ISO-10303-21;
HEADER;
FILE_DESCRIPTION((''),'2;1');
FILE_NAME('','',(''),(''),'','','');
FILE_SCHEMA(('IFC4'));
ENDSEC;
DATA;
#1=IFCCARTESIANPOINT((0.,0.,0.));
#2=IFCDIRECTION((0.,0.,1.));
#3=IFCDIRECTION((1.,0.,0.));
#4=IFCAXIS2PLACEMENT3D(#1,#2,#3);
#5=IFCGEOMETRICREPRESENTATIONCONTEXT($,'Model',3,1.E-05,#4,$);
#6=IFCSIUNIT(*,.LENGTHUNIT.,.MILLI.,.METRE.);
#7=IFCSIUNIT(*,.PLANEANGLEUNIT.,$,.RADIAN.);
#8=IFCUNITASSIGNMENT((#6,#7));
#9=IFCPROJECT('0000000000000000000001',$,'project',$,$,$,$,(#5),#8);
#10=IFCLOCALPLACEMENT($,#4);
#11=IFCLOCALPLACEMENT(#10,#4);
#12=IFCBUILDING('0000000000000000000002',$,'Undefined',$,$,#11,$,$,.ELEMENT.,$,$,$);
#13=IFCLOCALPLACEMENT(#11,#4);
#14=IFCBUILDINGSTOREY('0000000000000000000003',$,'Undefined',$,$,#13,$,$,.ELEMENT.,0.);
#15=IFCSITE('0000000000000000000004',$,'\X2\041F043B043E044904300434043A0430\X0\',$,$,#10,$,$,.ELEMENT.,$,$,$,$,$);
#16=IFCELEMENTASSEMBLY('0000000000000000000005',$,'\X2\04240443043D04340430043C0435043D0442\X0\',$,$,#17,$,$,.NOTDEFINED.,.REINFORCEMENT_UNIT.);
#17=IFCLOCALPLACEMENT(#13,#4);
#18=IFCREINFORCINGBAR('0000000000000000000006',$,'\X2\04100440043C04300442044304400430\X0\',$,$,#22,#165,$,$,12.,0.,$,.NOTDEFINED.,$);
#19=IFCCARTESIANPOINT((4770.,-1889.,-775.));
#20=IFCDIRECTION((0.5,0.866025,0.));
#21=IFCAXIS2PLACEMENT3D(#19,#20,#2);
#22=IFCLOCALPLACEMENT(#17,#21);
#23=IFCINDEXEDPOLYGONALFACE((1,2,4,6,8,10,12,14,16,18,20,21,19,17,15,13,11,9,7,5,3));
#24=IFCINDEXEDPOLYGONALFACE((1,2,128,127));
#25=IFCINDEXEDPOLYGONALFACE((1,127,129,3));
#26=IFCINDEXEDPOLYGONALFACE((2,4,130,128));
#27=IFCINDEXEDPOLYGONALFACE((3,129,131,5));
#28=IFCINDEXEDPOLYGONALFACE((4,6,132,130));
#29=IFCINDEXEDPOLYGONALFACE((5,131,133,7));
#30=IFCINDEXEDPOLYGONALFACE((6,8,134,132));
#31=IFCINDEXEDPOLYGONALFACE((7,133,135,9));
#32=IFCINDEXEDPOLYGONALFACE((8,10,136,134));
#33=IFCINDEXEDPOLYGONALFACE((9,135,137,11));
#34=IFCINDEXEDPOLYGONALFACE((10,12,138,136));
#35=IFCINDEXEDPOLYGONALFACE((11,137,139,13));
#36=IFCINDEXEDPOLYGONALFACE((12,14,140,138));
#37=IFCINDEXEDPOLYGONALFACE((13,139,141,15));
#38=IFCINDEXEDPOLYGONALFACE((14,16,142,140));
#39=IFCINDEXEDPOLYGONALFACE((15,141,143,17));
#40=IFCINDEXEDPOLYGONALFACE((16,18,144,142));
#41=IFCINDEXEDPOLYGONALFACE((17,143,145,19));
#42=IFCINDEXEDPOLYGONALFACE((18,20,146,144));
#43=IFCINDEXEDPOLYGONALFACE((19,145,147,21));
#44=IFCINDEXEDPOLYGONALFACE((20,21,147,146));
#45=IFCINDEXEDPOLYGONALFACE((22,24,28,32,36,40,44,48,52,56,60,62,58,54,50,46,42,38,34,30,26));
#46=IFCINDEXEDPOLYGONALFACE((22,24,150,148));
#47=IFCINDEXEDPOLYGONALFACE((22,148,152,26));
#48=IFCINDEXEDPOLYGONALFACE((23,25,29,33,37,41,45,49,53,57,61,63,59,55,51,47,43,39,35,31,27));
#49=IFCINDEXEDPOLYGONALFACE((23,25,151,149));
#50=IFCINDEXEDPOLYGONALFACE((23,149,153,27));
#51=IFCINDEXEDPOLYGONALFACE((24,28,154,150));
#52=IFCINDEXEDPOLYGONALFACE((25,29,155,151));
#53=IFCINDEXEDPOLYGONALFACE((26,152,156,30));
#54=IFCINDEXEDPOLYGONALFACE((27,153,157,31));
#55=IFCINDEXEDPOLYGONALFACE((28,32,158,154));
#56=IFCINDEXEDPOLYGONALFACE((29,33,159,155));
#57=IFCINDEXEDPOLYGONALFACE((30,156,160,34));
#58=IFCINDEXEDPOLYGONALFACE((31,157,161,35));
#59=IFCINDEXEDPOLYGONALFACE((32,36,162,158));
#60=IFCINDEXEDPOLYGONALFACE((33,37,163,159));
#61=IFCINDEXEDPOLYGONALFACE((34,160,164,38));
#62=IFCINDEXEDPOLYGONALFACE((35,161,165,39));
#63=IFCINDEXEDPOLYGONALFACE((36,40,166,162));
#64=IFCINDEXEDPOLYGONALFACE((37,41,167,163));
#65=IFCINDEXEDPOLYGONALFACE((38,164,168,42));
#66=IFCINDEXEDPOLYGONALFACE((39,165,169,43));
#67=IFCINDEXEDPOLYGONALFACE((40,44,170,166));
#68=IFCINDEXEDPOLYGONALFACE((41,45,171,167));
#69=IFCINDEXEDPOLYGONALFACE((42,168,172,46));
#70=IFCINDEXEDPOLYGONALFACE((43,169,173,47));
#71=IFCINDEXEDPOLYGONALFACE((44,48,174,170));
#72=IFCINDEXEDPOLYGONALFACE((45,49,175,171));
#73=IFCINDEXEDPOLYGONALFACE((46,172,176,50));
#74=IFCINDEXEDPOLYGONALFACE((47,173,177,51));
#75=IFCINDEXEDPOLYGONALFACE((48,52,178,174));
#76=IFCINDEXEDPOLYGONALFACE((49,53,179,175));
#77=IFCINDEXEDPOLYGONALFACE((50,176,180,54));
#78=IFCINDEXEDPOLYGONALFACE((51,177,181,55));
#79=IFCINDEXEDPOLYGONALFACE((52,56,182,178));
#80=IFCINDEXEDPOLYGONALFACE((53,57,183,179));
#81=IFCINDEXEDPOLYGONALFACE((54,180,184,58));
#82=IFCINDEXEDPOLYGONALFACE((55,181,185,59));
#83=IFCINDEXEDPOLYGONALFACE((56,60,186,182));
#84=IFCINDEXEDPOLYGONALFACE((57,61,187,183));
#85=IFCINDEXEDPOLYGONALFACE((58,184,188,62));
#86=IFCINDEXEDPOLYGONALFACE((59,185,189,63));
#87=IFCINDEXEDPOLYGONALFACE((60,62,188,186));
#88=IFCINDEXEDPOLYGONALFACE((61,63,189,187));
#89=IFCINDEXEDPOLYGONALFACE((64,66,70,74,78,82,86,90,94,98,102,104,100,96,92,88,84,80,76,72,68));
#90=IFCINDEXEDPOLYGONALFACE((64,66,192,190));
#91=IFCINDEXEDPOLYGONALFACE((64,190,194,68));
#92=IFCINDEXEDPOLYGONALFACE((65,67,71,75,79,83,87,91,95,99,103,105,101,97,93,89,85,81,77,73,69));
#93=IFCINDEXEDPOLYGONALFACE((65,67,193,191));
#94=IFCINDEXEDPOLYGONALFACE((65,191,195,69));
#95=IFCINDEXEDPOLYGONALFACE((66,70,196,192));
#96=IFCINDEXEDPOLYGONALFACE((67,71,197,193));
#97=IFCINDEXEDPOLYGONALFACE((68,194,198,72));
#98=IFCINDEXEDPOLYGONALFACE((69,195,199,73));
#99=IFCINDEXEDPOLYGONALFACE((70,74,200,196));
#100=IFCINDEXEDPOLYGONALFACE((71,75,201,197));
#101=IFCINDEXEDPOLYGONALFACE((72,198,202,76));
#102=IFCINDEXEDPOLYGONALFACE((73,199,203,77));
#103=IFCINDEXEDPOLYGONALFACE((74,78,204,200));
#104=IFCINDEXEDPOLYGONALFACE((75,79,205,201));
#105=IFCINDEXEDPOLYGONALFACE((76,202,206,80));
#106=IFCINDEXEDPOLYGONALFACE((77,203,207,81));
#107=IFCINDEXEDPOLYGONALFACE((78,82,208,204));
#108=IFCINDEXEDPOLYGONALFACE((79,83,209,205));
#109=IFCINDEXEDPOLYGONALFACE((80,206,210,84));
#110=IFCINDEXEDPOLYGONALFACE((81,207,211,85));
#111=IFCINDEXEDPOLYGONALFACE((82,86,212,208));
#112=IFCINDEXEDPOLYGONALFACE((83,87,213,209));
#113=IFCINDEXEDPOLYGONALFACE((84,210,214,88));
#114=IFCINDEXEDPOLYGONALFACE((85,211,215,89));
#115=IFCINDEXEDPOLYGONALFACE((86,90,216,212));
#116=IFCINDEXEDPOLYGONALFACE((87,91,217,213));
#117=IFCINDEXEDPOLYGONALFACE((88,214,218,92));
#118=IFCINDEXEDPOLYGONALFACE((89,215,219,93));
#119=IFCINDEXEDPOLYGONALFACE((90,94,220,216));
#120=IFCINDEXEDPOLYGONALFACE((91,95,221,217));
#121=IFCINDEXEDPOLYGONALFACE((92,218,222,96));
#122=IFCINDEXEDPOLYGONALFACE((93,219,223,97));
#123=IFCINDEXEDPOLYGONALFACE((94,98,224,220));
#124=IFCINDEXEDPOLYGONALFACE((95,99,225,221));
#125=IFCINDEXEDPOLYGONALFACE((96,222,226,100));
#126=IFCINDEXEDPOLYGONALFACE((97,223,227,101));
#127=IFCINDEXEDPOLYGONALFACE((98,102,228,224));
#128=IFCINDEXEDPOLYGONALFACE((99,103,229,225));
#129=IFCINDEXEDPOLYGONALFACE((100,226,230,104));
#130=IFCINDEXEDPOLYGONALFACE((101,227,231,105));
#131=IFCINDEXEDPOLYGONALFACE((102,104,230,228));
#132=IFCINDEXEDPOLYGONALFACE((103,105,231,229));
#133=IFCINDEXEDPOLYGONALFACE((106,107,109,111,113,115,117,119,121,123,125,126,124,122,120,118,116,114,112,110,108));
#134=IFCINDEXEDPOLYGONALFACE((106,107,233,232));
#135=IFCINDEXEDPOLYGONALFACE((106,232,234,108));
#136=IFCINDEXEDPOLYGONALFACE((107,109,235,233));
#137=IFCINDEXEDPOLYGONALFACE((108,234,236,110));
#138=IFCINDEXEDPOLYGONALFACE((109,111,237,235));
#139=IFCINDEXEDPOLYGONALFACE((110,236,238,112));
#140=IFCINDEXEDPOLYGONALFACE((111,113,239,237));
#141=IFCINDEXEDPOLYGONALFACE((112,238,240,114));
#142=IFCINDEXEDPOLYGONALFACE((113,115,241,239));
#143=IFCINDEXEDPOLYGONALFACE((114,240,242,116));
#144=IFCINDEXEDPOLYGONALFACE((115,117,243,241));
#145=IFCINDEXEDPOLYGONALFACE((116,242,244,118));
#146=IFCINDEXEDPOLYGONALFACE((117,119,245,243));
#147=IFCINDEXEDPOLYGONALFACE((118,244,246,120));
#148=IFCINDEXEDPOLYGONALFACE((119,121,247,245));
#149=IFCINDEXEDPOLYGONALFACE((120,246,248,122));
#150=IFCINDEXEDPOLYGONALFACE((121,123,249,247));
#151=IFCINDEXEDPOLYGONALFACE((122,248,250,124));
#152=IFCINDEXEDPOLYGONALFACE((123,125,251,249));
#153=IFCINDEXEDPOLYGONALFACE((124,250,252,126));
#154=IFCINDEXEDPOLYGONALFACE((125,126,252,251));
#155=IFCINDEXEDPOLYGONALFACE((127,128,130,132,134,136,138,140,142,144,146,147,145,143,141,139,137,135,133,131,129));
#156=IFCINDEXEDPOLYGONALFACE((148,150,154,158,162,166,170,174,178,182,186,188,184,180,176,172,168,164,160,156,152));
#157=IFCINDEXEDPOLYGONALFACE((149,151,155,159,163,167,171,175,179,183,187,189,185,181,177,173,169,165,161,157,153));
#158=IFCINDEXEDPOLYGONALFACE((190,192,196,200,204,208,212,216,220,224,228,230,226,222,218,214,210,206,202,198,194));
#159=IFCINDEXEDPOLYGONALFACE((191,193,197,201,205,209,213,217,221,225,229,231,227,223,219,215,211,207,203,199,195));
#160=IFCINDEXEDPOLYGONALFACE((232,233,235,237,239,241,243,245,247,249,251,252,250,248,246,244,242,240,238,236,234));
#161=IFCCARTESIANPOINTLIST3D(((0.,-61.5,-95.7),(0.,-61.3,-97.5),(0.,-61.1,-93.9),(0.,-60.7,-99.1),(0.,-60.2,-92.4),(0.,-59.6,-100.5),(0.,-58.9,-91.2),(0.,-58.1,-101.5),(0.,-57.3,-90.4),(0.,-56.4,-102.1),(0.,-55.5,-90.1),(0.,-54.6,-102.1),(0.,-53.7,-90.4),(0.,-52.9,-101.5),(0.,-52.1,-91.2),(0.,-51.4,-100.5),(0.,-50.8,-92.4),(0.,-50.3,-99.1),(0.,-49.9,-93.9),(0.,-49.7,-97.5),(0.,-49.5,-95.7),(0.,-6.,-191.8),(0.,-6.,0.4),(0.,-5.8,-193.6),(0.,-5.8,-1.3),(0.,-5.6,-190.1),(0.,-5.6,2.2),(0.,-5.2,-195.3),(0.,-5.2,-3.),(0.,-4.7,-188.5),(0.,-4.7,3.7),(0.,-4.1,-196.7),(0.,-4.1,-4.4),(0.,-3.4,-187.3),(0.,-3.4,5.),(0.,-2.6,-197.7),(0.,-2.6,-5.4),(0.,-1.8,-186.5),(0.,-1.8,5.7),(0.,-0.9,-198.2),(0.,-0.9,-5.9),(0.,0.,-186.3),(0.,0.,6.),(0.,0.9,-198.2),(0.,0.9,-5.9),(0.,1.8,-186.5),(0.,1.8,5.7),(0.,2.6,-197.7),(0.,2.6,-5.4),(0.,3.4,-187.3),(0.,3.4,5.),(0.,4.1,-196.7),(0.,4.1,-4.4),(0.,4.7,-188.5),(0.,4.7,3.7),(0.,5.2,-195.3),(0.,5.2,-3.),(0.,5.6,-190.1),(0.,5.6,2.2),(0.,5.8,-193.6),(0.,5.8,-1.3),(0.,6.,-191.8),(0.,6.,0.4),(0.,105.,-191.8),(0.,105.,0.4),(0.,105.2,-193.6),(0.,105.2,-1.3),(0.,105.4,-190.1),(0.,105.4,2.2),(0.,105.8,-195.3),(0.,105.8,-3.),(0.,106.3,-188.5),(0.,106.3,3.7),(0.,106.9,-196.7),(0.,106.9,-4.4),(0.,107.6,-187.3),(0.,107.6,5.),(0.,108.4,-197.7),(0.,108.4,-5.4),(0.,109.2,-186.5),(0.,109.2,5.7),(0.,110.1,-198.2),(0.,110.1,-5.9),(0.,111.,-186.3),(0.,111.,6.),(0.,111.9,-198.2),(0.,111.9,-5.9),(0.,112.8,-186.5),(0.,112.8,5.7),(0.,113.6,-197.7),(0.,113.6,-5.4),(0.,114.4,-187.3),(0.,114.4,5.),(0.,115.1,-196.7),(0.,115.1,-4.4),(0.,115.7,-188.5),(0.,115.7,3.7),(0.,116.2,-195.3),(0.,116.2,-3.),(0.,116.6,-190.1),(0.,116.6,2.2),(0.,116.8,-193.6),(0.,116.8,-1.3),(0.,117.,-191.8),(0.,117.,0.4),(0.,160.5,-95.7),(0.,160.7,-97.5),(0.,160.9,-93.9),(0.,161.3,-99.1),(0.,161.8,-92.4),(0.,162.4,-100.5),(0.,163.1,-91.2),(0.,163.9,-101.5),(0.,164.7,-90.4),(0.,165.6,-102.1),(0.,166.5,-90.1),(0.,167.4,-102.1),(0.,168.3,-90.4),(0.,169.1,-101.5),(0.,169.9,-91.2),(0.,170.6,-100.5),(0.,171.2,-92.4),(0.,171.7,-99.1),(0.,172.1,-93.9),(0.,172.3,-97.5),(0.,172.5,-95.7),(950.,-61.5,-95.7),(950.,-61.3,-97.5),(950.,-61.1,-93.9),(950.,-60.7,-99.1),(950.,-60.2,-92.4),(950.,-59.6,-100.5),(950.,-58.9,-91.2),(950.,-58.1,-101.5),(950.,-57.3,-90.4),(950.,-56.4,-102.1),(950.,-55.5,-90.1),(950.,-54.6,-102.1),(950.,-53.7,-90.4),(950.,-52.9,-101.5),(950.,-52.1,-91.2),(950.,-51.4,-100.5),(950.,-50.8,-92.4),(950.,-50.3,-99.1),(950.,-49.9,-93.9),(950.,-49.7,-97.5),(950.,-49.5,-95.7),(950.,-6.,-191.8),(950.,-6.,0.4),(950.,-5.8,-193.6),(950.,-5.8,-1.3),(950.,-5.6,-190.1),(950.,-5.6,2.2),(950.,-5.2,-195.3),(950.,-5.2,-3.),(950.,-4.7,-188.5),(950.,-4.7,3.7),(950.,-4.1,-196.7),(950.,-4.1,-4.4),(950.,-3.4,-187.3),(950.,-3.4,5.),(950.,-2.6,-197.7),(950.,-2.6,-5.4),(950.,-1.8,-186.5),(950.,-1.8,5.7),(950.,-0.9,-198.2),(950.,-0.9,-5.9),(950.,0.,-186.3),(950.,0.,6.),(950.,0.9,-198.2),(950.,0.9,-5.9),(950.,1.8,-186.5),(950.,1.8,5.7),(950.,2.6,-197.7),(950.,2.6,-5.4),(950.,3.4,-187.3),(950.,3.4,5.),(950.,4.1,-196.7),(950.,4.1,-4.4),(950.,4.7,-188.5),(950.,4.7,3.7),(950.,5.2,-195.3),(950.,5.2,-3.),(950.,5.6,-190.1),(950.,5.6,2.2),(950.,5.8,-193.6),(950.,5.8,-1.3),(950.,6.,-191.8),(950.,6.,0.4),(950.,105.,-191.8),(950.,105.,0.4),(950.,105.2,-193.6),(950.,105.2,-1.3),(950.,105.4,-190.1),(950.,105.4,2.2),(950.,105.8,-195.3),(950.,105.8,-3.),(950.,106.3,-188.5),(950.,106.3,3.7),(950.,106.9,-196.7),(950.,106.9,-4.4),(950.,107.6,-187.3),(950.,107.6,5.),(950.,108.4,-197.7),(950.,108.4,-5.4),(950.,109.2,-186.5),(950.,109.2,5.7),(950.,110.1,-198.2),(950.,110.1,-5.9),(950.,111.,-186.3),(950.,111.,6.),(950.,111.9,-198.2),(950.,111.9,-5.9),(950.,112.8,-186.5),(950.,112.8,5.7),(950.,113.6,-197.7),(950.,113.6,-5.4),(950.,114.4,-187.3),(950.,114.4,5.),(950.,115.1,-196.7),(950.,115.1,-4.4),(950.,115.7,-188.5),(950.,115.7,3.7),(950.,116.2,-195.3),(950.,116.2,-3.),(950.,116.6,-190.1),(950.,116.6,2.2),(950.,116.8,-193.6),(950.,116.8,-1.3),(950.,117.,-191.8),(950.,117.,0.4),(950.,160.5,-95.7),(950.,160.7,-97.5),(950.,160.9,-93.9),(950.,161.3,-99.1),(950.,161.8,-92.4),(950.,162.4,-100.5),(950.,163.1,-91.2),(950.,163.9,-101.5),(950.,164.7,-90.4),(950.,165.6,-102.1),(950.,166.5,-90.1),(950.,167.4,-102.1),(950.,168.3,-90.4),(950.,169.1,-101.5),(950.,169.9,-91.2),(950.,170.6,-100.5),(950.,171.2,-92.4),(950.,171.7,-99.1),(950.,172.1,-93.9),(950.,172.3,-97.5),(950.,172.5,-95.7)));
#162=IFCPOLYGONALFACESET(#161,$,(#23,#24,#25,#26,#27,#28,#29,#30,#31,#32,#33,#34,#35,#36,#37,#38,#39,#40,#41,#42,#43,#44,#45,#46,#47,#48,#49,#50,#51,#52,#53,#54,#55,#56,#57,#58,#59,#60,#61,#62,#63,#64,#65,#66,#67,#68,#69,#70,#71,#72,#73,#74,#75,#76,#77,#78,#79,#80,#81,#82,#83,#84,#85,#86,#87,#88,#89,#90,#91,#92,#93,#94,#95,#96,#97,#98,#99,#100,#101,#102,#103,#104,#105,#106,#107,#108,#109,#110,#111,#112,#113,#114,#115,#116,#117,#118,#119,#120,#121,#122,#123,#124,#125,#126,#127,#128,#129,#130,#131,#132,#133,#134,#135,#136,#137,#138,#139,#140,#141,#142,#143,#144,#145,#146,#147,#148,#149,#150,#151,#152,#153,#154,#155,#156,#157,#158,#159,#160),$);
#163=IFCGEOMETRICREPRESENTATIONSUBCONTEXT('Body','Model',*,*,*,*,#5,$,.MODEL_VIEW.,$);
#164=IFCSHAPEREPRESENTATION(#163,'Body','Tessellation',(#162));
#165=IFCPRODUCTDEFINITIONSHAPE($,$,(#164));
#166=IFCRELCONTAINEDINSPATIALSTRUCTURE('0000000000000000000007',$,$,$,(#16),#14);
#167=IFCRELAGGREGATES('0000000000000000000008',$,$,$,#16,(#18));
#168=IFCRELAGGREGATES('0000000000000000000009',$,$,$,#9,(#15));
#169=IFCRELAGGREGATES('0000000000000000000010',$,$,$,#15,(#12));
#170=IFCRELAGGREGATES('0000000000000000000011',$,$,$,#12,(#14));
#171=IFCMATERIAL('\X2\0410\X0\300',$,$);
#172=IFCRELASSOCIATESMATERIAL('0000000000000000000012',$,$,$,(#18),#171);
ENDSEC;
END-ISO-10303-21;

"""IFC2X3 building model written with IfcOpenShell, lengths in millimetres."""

from ifc_helpers import new_model, entity, si_unit, frame, origin_with_axes, place, context, subcontext, project, spatial, source, transform, mapped, material, element, aggregate, save


model = new_model("IFC2X3")

# Units and contexts
model_context = context("Model", 3, precision=1e-05, world=origin_with_axes())
body_context = subcontext(model_context, "Body", "Model", "MODEL_VIEW")
ifc_project = project(units=[si_unit("LENGTHUNIT", "METRE", prefix="MILLI"), si_unit("PLANEANGLEUNIT", "RADIAN")], contexts=[model_context])

# Site, building, storey
site_placement = place(None, origin_with_axes())
site = spatial("IfcSite", under=ifc_project, at=site_placement, Name="Площадка", CompositionType="ELEMENT")
building_placement = place(site_placement, origin_with_axes())
building = spatial("IfcBuilding", under=site, at=building_placement, Name="Undefined", CompositionType="ELEMENT")
storey_placement = place(building_placement, origin_with_axes())
storey = spatial("IfcBuildingStorey", under=building, at=storey_placement, Name="Undefined", CompositionType="ELEMENT", Elevation=0.0)

# Element assembly
assembly_1_placement = place(storey_placement, origin_with_axes())
assembly_1 = element("IfcElementAssembly", 1, at=assembly_1_placement, inside=storey, Name="Фундамент", AssemblyPlace="NOTDEFINED", PredefinedType="REINFORCEMENT_UNIT")

# Reinforcing bar
ifc_material_1 = material(Name="А300")
shared_shape_1 = source(origin_with_axes(), body_context, "Body", "AdvancedSweptSolid", [
    entity("IfcSweptDiskSolid", entity("IfcTrimmedCurve", entity("IfcLine", entity("IfcCartesianPoint", [0.0, 0.0, 0.0]), entity("IfcVector", entity("IfcDirection", [1.0, 0.0, 0.0]), 1.0)), [entity("IfcParameterValue", 0.0)], [entity("IfcParameterValue", 950.0)], True, "PARAMETER"), 6.0, None, 0.0, 950.0),
])
shared_shape_2 = source(origin_with_axes(), body_context, "Body", "AdvancedSweptSolid", [
    entity("IfcSweptDiskSolid", entity("IfcTrimmedCurve", entity("IfcLine", entity("IfcCartesianPoint", [0.0, 0.0, 0.0]), entity("IfcVector", entity("IfcDirection", [1.0, 0.0, 0.0]), 1.0)), [entity("IfcParameterValue", 0.0)], [entity("IfcParameterValue", 950.0)], True, "PARAMETER"), 6.0, None, 0.0, 950.0),
])
shared_shape_3 = source(origin_with_axes(), body_context, "Body", "AdvancedSweptSolid", [
    entity("IfcSweptDiskSolid", entity("IfcTrimmedCurve", entity("IfcLine", entity("IfcCartesianPoint", [0.0, 0.0, 0.0]), entity("IfcVector", entity("IfcDirection", [1.0, 0.0, 0.0]), 1.0)), [entity("IfcParameterValue", 0.0)], [entity("IfcParameterValue", 950.0)], True, "PARAMETER"), 6.0, None, 0.0, 950.0),
])
shared_shape_4 = source(origin_with_axes(), body_context, "Body", "AdvancedSweptSolid", [
    entity("IfcSweptDiskSolid", entity("IfcTrimmedCurve", entity("IfcLine", entity("IfcCartesianPoint", [0.0, 0.0, 0.0]), entity("IfcVector", entity("IfcDirection", [1.0, 0.0, 0.0]), 1.0)), [entity("IfcParameterValue", 0.0)], [entity("IfcParameterValue", 950.0)], True, "PARAMETER"), 6.0, None, 0.0, 950.0),
])
shared_shape_5 = source(origin_with_axes(), body_context, "Body", "AdvancedSweptSolid", [
    entity("IfcSweptDiskSolid", entity("IfcTrimmedCurve", entity("IfcLine", entity("IfcCartesianPoint", [0.0, 0.0, 0.0]), entity("IfcVector", entity("IfcDirection", [1.0, 0.0, 0.0]), 1.0)), [entity("IfcParameterValue", 0.0)], [entity("IfcParameterValue", 950.0)], True, "PARAMETER"), 6.0, None, 0.0, 950.0),
])
shared_shape_6 = source(origin_with_axes(), body_context, "Body", "AdvancedSweptSolid", [
    entity("IfcSweptDiskSolid", entity("IfcTrimmedCurve", entity("IfcLine", entity("IfcCartesianPoint", [0.0, 0.0, 0.0]), entity("IfcVector", entity("IfcDirection", [1.0, 0.0, 0.0]), 1.0)), [entity("IfcParameterValue", 0.0)], [entity("IfcParameterValue", 950.0)], True, "PARAMETER"), 6.0, None, 0.0, 950.0),
])
reinforcing_bar_1_placement = place(assembly_1_placement, frame((4770.0, -1889.0, -775.0), z_axis=(0.5, 0.866025, 0.0), x_axis=(0.0, 0.0, 1.0)))
reinforcing_bar_1 = element("IfcReinforcingBar", 2, at=reinforcing_bar_1_placement, material=ifc_material_1, Name="Арматура", BarRole="NOTDEFINED", CrossSectionArea=0.0, NominalDiameter=12.0, context=body_context, shape_type="MappedRepresentation", body=[
    mapped(shared_shape_1, transform((0.0, 0.0, 0.0))),
    mapped(shared_shape_2, transform((0.0, -55.5, -96.1))),
    mapped(shared_shape_3, transform((0.0, 0.0, -192.3))),
    mapped(shared_shape_4, transform((0.0, 111.0, -192.3))),
    mapped(shared_shape_5, transform((0.0, 166.5, -96.1))),
    mapped(shared_shape_6, transform((0.0, 111.0, 0.0))),
])
aggregate(assembly_1, [reinforcing_bar_1])

save(model, "model.ifc")
